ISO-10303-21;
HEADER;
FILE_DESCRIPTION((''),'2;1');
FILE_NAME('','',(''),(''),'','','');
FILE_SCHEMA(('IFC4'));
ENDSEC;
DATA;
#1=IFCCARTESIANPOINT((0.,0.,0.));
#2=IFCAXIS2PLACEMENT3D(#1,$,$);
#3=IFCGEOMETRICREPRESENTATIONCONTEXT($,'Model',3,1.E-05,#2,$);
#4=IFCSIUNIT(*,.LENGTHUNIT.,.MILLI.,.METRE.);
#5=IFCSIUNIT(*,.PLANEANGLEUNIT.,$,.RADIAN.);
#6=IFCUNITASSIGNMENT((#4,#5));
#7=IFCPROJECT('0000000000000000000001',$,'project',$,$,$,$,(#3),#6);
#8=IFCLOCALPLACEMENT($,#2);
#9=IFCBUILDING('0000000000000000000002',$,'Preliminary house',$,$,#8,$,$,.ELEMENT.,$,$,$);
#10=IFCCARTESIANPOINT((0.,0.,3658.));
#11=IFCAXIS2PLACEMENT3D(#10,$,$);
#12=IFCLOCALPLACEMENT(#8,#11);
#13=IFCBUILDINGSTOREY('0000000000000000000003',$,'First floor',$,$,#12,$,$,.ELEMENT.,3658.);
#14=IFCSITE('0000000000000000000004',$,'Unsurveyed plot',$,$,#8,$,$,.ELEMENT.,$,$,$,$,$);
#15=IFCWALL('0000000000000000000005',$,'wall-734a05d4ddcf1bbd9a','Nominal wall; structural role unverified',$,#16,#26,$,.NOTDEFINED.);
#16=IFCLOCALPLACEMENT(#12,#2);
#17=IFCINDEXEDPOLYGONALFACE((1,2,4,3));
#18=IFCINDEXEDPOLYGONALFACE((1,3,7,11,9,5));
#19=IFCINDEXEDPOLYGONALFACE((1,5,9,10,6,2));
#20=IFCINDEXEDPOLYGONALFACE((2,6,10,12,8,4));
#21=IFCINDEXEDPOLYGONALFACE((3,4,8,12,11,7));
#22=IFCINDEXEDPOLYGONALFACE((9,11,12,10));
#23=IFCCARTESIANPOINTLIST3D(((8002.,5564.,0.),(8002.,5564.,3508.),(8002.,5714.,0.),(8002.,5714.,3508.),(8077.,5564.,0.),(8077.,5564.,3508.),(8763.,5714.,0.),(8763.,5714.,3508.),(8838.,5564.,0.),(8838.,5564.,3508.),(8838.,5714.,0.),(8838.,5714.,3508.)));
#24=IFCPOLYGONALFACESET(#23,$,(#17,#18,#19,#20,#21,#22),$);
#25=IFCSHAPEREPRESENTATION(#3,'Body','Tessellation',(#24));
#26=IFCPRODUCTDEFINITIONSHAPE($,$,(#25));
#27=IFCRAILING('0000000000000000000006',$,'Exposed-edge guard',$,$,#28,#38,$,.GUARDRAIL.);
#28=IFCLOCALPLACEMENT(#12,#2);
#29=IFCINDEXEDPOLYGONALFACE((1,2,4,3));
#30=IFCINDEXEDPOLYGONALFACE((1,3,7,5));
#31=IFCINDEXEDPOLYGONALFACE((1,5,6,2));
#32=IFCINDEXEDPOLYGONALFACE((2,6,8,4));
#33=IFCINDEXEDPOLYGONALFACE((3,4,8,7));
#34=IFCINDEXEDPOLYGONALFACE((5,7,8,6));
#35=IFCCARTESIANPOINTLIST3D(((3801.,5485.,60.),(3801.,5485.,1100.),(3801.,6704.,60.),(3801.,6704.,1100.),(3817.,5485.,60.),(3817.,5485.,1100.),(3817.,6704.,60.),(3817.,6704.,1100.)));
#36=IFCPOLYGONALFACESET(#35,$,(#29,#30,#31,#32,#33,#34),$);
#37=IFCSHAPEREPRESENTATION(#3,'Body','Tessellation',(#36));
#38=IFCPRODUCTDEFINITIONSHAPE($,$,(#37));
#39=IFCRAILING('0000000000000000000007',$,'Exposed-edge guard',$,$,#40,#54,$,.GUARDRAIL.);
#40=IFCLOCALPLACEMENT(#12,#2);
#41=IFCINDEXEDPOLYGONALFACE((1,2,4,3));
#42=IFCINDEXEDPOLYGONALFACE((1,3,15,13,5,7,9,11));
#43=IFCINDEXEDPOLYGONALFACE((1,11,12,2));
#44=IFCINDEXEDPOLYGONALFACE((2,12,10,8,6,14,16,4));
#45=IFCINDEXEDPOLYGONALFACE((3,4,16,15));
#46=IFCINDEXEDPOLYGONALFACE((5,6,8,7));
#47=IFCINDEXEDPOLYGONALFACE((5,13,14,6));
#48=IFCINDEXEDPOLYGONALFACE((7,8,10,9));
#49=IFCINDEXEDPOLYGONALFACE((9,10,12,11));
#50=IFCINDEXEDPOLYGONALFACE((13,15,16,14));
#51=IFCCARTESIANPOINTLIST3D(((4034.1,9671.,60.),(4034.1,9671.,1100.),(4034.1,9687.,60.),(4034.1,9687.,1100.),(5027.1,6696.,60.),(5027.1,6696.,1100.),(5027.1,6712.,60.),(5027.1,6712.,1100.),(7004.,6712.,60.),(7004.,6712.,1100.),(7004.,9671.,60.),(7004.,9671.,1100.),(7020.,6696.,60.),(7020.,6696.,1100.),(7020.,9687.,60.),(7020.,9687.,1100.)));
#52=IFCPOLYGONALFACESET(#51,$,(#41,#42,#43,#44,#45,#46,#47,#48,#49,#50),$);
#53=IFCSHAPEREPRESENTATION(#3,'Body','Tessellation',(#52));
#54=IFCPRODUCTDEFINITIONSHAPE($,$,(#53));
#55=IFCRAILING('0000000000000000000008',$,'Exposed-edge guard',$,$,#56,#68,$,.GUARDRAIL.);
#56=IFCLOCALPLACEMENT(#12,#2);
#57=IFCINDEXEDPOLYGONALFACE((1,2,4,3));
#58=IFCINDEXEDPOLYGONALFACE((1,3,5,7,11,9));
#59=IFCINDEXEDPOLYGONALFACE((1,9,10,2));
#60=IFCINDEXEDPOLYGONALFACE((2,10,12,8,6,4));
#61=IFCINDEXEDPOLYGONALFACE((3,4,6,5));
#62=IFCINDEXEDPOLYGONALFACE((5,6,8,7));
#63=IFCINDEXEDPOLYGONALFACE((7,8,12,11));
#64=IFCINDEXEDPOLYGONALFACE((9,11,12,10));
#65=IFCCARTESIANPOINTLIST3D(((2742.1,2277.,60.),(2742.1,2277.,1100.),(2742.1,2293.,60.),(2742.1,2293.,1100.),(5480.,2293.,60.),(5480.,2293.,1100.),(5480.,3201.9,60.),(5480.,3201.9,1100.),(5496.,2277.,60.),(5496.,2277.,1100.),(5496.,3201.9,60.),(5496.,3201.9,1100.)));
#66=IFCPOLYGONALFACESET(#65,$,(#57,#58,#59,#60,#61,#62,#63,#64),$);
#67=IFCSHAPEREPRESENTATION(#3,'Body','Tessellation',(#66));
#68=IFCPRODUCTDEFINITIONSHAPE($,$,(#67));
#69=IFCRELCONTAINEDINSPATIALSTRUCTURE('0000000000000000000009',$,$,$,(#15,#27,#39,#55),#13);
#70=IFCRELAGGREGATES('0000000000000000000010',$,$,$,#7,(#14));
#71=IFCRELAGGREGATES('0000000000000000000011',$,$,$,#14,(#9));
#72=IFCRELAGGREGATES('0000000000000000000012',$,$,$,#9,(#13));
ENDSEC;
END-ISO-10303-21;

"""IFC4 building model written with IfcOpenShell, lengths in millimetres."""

from ifc_helpers import new_model, si_unit, frame, origin, place, context, project, spatial, polyline, outline, extrude, element, save


model = new_model("IFC4")

# Units and contexts
model_context = context("Model", 3, precision=1e-05, world=origin())
ifc_project = project(units=[si_unit("LENGTHUNIT", "METRE", prefix="MILLI"), si_unit("PLANEANGLEUNIT", "RADIAN")], contexts=[model_context])

# Site, building, storey
placement_1 = place(None, origin())
site = spatial("IfcSite", under=ifc_project, at=placement_1, Name="Unsurveyed plot", CompositionType="ELEMENT")
building = spatial("IfcBuilding", under=site, at=placement_1, Name="Preliminary house", CompositionType="ELEMENT")
placement_2 = place(placement_1, frame((0.0, 0.0, 3658.0)))
storey = spatial("IfcBuildingStorey", under=building, at=placement_2, Name="First floor", CompositionType="ELEMENT", Elevation=3658.0)

# Wall
element("IfcWall", 1, at=placement_2, inside=storey, Name="wall-734a05d4ddcf1bbd9a", Description="Nominal wall; structural role unverified", PredefinedType="NOTDEFINED", context=model_context, shape_type="SweptSolid", body=[
    extrude(outline(polyline([(8763.0, 5714.0), (8838.0, 5714.0), (8838.0, 5564.0), (8077.0, 5564.0), (8002.0, 5564.0), (8002.0, 5714.0), (8763.0, 5714.0)])), origin(), (0.0, 0.0, 1.0), 3508.0),
])

# Railings
element("IfcRailing", 2, at=placement_2, inside=storey, Name="Exposed-edge guard", PredefinedType="GUARDRAIL", context=model_context, shape_type="SweptSolid", body=[
    extrude(outline(polyline([(3801.0, 6704.0), (3817.0, 6704.0), (3817.0, 5485.0), (3801.0, 5485.0), (3801.0, 6704.0)])), frame((0.0, 0.0, 60.0)), (0.0, 0.0, 1.0), 1040.0),
])
element("IfcRailing", 3, at=placement_2, inside=storey, Name="Exposed-edge guard", PredefinedType="GUARDRAIL", context=model_context, shape_type="SweptSolid", body=[
    extrude(outline(polyline([(7004.0, 6712.0), (7004.0, 9671.0), (4034.1, 9671.0), (4034.1, 9687.0), (7020.0, 9687.0), (7020.0, 6696.0), (5027.1, 6696.0), (5027.1, 6712.0), (7004.0, 6712.0)])), frame((0.0, 0.0, 60.0)), (0.0, 0.0, 1.0), 1040.0),
])
element("IfcRailing", 4, at=placement_2, inside=storey, Name="Exposed-edge guard", PredefinedType="GUARDRAIL", context=model_context, shape_type="SweptSolid", body=[
    extrude(outline(polyline([(5480.0, 2293.0), (5480.0, 3201.9), (5496.0, 3201.9), (5496.0, 2277.0), (2742.1, 2277.0), (2742.1, 2293.0), (5480.0, 2293.0)])), frame((0.0, 0.0, 60.0)), (0.0, 0.0, 1.0), 1040.0),
])

save(model, "model.ifc")
